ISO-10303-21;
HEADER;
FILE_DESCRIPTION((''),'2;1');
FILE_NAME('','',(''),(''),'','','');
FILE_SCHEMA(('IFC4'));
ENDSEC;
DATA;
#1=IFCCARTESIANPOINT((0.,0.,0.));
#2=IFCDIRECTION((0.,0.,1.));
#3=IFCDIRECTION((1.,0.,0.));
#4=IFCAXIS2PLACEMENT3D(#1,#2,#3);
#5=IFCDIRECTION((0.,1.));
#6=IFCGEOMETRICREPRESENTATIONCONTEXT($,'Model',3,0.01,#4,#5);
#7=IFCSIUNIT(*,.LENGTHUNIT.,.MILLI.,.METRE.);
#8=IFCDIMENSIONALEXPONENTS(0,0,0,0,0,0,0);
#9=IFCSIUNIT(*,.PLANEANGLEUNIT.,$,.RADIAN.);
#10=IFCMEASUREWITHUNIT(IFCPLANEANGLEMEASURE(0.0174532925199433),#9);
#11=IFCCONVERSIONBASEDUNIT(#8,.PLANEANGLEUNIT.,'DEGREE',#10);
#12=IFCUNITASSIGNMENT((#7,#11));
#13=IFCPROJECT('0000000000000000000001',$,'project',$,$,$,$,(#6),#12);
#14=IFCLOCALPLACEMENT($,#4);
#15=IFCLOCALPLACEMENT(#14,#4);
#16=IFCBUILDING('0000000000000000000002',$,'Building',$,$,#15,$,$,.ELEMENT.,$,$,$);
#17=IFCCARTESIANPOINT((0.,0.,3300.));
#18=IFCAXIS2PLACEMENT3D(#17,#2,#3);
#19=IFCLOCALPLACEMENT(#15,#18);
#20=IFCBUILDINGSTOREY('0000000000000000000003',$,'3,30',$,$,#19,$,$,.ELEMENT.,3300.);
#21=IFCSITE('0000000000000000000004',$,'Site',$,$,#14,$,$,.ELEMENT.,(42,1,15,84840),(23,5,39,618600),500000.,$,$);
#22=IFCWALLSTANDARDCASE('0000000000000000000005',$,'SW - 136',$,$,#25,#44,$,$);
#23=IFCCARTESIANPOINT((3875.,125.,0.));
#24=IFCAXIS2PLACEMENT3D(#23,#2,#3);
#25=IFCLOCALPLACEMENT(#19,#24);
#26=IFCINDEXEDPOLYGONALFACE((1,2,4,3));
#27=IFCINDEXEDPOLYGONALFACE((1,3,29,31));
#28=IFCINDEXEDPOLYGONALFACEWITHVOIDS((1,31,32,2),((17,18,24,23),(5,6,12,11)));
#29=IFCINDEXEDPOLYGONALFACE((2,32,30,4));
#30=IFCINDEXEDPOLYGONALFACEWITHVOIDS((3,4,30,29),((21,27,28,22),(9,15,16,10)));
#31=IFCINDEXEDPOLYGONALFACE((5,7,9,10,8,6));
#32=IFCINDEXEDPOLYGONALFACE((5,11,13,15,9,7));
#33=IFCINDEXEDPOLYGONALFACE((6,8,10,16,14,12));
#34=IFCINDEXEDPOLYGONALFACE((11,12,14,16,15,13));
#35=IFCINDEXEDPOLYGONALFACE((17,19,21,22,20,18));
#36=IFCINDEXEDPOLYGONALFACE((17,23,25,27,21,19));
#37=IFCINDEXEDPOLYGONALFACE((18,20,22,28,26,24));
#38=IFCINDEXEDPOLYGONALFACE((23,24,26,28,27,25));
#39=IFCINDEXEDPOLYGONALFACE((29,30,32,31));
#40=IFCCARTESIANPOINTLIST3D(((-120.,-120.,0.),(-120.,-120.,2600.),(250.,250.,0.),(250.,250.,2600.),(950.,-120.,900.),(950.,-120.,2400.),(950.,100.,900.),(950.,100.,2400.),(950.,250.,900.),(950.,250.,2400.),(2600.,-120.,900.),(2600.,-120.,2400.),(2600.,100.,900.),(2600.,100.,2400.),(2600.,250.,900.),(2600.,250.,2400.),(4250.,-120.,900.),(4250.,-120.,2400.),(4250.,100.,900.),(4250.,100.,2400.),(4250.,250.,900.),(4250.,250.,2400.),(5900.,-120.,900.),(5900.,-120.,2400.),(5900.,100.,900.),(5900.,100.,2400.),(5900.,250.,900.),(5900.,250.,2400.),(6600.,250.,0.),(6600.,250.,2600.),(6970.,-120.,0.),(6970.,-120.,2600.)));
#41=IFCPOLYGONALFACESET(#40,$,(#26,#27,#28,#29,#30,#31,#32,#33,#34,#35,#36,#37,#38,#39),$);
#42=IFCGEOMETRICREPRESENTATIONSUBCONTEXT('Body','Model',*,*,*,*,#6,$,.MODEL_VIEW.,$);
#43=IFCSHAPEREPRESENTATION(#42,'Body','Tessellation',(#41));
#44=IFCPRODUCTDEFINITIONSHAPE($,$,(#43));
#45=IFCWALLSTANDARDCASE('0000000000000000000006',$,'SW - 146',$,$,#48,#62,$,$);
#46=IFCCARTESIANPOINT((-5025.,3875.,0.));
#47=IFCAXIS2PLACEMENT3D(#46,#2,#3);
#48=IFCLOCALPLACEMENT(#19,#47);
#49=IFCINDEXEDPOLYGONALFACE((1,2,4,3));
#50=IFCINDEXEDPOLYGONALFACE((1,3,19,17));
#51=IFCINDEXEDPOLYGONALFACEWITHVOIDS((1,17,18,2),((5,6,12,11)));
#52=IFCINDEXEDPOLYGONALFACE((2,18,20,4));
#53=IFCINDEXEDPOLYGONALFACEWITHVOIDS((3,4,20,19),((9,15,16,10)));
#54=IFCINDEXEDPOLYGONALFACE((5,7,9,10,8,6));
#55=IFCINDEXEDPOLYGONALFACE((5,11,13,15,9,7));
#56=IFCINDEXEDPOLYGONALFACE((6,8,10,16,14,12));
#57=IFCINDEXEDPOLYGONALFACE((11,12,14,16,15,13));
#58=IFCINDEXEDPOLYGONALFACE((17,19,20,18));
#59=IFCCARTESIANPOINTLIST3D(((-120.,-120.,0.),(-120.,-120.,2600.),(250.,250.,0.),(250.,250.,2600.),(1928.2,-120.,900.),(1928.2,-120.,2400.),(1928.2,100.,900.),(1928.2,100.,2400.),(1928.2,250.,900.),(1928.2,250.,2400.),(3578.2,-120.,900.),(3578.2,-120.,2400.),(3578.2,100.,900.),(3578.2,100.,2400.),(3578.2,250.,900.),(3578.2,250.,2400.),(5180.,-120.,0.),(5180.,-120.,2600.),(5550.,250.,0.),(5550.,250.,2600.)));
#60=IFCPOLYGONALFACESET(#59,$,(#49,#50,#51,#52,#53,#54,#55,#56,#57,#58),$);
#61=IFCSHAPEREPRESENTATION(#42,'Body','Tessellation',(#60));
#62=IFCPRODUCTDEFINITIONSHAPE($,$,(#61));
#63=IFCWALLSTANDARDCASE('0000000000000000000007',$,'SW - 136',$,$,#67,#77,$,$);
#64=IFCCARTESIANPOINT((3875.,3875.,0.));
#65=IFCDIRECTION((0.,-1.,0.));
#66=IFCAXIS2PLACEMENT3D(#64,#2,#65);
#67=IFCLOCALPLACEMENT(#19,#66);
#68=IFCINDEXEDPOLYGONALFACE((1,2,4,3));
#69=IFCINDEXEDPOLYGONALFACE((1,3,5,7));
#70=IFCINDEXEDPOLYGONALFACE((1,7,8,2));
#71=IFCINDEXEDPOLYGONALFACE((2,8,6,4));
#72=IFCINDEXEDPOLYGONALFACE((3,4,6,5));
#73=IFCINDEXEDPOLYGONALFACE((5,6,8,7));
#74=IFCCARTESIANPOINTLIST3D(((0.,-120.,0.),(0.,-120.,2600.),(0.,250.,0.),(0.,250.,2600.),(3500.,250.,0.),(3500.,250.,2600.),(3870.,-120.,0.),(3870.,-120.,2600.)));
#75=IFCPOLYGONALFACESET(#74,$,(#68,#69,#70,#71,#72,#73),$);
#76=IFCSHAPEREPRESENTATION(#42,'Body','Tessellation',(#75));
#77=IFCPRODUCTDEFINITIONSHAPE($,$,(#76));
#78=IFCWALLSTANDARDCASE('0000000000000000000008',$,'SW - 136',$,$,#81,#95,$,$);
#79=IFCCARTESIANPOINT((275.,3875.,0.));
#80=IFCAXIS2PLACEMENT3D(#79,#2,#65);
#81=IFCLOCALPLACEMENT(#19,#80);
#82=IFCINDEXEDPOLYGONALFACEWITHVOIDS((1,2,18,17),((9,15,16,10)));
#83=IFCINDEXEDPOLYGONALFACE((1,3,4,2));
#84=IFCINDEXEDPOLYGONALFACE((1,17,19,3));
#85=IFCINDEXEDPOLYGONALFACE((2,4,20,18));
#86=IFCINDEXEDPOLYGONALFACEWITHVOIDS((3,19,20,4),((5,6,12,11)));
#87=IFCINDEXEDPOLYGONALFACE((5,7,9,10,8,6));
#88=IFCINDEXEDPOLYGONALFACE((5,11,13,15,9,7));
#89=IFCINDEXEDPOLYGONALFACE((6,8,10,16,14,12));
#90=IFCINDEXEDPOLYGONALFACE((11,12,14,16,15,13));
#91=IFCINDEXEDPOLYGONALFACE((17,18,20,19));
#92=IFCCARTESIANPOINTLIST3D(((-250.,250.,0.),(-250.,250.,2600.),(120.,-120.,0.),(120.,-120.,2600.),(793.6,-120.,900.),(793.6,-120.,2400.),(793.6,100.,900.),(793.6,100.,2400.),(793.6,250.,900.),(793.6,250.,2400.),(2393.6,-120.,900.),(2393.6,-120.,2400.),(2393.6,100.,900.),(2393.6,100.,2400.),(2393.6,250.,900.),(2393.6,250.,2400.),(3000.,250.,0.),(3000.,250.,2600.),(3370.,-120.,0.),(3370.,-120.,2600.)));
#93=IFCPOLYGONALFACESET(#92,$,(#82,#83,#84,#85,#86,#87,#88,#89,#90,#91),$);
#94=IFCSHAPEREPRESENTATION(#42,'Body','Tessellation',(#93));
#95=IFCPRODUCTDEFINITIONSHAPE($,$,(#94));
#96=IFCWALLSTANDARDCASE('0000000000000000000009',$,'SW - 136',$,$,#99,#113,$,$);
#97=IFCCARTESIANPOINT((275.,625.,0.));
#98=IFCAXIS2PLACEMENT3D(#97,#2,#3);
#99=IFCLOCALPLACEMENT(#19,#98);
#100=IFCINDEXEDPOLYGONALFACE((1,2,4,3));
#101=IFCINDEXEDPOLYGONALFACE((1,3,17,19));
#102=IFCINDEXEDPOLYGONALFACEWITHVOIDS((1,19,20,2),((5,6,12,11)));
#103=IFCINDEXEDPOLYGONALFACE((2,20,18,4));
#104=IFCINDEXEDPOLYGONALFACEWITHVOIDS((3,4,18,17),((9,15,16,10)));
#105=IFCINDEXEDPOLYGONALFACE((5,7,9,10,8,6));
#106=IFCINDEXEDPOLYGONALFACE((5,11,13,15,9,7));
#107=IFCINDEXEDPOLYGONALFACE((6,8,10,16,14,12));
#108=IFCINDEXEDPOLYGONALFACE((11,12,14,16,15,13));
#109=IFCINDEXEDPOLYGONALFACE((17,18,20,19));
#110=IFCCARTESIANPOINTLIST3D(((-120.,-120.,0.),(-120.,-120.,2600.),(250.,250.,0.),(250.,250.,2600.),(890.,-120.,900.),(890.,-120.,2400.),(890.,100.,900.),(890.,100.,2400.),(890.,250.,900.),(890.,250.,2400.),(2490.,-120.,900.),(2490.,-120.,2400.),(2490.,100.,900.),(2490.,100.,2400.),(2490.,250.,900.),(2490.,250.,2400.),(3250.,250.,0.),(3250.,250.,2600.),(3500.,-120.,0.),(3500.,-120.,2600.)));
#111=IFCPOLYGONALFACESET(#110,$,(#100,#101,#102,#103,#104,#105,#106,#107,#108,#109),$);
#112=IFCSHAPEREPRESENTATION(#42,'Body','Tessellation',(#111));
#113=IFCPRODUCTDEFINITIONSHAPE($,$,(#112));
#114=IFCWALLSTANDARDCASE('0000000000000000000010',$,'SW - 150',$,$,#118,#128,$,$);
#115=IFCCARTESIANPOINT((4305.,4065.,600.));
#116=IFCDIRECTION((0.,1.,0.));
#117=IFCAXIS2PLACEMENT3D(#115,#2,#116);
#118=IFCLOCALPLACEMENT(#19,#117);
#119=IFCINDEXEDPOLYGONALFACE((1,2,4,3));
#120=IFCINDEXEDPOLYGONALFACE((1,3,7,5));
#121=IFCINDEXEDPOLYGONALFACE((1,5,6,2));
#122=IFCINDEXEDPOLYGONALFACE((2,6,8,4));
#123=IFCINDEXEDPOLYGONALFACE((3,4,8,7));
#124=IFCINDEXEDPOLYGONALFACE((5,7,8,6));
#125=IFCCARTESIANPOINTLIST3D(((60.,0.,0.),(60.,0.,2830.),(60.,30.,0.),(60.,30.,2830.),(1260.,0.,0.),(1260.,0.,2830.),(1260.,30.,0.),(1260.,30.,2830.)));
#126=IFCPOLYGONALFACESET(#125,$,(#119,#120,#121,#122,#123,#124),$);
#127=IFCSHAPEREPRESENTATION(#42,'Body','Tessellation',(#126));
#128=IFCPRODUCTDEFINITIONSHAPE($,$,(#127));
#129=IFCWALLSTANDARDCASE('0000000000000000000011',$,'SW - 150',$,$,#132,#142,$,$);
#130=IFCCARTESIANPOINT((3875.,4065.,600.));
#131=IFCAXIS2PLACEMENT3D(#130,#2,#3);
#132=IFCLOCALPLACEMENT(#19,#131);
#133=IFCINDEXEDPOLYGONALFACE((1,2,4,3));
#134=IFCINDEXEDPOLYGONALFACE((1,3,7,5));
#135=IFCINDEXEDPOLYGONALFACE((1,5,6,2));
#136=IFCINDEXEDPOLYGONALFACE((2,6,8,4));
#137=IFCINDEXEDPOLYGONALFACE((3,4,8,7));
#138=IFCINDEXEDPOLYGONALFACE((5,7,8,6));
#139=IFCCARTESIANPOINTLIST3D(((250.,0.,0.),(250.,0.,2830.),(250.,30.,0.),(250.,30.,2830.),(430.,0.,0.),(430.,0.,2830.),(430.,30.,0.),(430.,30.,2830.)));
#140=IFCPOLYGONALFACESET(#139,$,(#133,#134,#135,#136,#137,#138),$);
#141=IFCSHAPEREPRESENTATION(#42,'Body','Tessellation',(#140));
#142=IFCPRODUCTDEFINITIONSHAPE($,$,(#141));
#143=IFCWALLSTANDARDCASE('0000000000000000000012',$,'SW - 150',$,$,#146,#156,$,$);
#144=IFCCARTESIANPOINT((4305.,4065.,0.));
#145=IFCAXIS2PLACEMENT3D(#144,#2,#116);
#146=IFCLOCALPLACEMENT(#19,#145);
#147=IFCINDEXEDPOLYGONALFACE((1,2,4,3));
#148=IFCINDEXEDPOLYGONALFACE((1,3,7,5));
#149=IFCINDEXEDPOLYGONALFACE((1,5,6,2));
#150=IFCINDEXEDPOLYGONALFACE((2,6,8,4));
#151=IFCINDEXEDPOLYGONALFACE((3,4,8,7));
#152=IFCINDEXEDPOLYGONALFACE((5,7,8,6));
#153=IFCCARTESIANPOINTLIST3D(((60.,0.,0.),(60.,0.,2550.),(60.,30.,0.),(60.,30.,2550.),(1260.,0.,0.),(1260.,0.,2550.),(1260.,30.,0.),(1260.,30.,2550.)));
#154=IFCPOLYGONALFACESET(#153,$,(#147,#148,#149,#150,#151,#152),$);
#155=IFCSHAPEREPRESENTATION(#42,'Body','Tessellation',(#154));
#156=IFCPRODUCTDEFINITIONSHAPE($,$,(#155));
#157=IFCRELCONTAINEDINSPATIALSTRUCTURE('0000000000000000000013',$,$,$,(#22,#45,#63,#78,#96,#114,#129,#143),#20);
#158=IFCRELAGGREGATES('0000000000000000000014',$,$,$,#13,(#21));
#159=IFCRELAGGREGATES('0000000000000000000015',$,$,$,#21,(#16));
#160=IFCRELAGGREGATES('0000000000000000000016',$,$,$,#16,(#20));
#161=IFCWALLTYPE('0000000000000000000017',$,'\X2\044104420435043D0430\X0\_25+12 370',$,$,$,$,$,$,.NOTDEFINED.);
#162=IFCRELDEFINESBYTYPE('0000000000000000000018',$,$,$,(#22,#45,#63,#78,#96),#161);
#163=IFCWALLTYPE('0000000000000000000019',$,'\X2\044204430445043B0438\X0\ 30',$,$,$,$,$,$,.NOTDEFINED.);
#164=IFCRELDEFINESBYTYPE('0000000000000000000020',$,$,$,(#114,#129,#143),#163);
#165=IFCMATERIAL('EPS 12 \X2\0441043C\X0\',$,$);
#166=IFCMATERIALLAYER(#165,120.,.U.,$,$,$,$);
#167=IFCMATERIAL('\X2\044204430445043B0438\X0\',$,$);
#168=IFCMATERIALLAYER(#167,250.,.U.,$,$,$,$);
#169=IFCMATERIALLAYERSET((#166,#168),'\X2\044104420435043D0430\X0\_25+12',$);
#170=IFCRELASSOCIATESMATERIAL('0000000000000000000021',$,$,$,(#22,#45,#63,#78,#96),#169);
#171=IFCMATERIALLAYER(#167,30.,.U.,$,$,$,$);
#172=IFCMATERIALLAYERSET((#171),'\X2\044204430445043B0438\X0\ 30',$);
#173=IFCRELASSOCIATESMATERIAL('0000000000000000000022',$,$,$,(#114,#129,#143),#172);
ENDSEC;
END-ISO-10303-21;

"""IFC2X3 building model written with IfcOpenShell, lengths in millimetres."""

from ifc_helpers import new_model, entity, si_unit, converted_unit, direction, frame, origin_with_axes, origin_2d_with_axis, place, context, subcontext, project, spatial, polyline, rectangle, outline, extrude, material, layer, layer_set, layer_usage, type_object, element, save


model = new_model("IFC2X3")

# Units and contexts
model_context = context("Model", 3, precision=0.01, world=origin_with_axes(), true_north=direction((0.0, 1.0)))
body_context = subcontext(model_context, "Body", "Model", "MODEL_VIEW")
ifc_project = project(units=[si_unit("LENGTHUNIT", "METRE", prefix="MILLI"), converted_unit("PLANEANGLEUNIT", "DEGREE", entity("IfcPlaneAngleMeasure", 0.0174532925199433), si_unit("PLANEANGLEUNIT", "RADIAN"), dimensions=[0, 0, 0, 0, 0, 0, 0])], contexts=[model_context])

# Site, building, storey
site_placement = place(None, origin_with_axes())
site = spatial("IfcSite", under=ifc_project, at=site_placement, Name="Site", CompositionType="ELEMENT", RefLatitude=(42, 1, 15, 84840), RefLongitude=(23, 5, 39, 618600), RefElevation=500000.0)
building_placement = place(site_placement, origin_with_axes())
building = spatial("IfcBuilding", under=site, at=building_placement, Name="Building", CompositionType="ELEMENT")
storey_placement = place(building_placement, frame((0.0, 0.0, 3300.0), z_axis=(0.0, 0.0, 1.0), x_axis=(1.0, 0.0, 0.0)))
storey = spatial("IfcBuildingStorey", under=building, at=storey_placement, Name="3,30", CompositionType="ELEMENT", Elevation=3300.0)

# Wall, openings
ifc_material_1 = material(Name="EPS 12 см")
ifc_layer_1 = layer(ifc_material_1, 120.0, ventilated="UNKNOWN")
ifc_material_2 = material(Name="тухли")
ifc_layer_2 = layer(ifc_material_2, 250.0, ventilated="UNKNOWN")
ifc_layer_set_1 = layer_set([ifc_layer_1, ifc_layer_2], Name="стена_25+12")
ifc_layer_usage_1 = layer_usage(ifc_layer_set_1, "AXIS2", "POSITIVE", -120.0)
wall_type_1 = type_object("IfcWallType", Name="стена_25+12 370", PredefinedType="NOTDEFINED")
wall_1_placement = place(storey_placement, frame((3875.0, 125.0, 0.0), z_axis=(0.0, 0.0, 1.0), x_axis=(1.0, 0.0, 0.0)))
wall_1 = element("IfcWallStandardCase", 1, at=wall_1_placement, inside=storey, type_object=wall_type_1, material=ifc_layer_usage_1, Name="SW - 136", context=body_context, shape_type="SweptSolid", body=[
    extrude(outline(polyline([(-120.0, -120.0), (6970.0, -120.0), (6600.0, 250.0), (250.0, 250.0), (-120.0, -120.0)])), origin_with_axes(), (0.0, 0.0, 1.0), 2600.0),
])
opening_1_placement = place(wall_1_placement, frame((5075.0, 0.0, 900.0), z_axis=(0.0, 0.0, 1.0), x_axis=(1.0, 0.0, 0.0)))
element("IfcOpeningElement", 2, at=opening_1_placement, cuts=wall_1, context=body_context, shape_type="SweptSolid", body=[
    extrude(rectangle(XDim=1650.0, YDim=1500.0, at=origin_2d_with_axis()), frame((0.0, 100.0, 750.0), z_axis=(0.0, -1.0, 0.0), x_axis=(-1.0, 0.0, 0.0)), (0.0, 0.0, 1.0), 590.0),
    extrude(rectangle(XDim=1650.0, YDim=1500.0, at=origin_2d_with_axis()), frame((0.0, 100.0, 750.0), z_axis=(0.0, 1.0, 0.0), x_axis=(-1.0, 0.0, 0.0)), (0.0, 0.0, 1.0), 520.0),
])
opening_2_placement = place(wall_1_placement, frame((1775.0, 0.0, 900.0), z_axis=(0.0, 0.0, 1.0), x_axis=(1.0, 0.0, 0.0)))
element("IfcOpeningElement", 3, at=opening_2_placement, cuts=wall_1, context=body_context, shape_type="SweptSolid", body=[
    extrude(rectangle(XDim=1650.0, YDim=1500.0, at=origin_2d_with_axis()), frame((0.0, 100.0, 750.0), z_axis=(0.0, -1.0, 0.0), x_axis=(-1.0, 0.0, 0.0)), (0.0, 0.0, 1.0), 590.0),
    extrude(rectangle(XDim=1650.0, YDim=1500.0, at=origin_2d_with_axis()), frame((0.0, 100.0, 750.0), z_axis=(0.0, 1.0, 0.0), x_axis=(-1.0, 0.0, 0.0)), (0.0, 0.0, 1.0), 520.0),
])

# Wall, opening
ifc_layer_usage_2 = layer_usage(ifc_layer_set_1, "AXIS2", "POSITIVE", -120.0)
wall_2_placement = place(storey_placement, frame((-5025.0, 3875.0, 0.0), z_axis=(0.0, 0.0, 1.0), x_axis=(1.0, 0.0, 0.0)))
wall_2 = element("IfcWallStandardCase", 4, at=wall_2_placement, inside=storey, type_object=wall_type_1, material=ifc_layer_usage_2, Name="SW - 146", context=body_context, shape_type="SweptSolid", body=[
    extrude(outline(polyline([(-120.0, -120.0), (5180.0, -120.0), (5550.0, 250.0), (250.0, 250.0), (-120.0, -120.0)])), origin_with_axes(), (0.0, 0.0, 1.0), 2600.0),
])
opening_3_placement = place(wall_2_placement, frame((2753.2, 0.0, 900.0), z_axis=(0.0, 0.0, 1.0), x_axis=(1.0, 0.0, 0.0)))
element("IfcOpeningElement", 5, at=opening_3_placement, cuts=wall_2, context=body_context, shape_type="SweptSolid", body=[
    extrude(rectangle(XDim=1650.0, YDim=1500.0, at=origin_2d_with_axis()), frame((0.0, 100.0, 750.0), z_axis=(0.0, -1.0, 0.0), x_axis=(-1.0, 0.0, 0.0)), (0.0, 0.0, 1.0), 590.0),
    extrude(rectangle(XDim=1650.0, YDim=1500.0, at=origin_2d_with_axis()), frame((0.0, 100.0, 750.0), z_axis=(0.0, 1.0, 0.0), x_axis=(-1.0, 0.0, 0.0)), (0.0, 0.0, 1.0), 520.0),
])

# Wall
ifc_layer_usage_3 = layer_usage(ifc_layer_set_1, "AXIS2", "POSITIVE", -120.0)
wall_3_placement = place(storey_placement, frame((3875.0, 3875.0, 0.0), z_axis=(0.0, 0.0, 1.0), x_axis=(0.0, -1.0, 0.0)))
element("IfcWallStandardCase", 6, at=wall_3_placement, inside=storey, type_object=wall_type_1, material=ifc_layer_usage_3, Name="SW - 136", context=body_context, shape_type="SweptSolid", body=[
    extrude(outline(polyline([(0.0, -120.0), (3870.0, -120.0), (3500.0, 250.0), (0.0, 250.0), (0.0, -120.0)])), origin_with_axes(), (0.0, 0.0, 1.0), 2600.0),
])

# Walls, openings
ifc_layer_usage_4 = layer_usage(ifc_layer_set_1, "AXIS2", "POSITIVE", -120.0)
wall_4_placement = place(storey_placement, frame((275.0, 3875.0, 0.0), z_axis=(0.0, 0.0, 1.0), x_axis=(0.0, -1.0, 0.0)))
wall_4 = element("IfcWallStandardCase", 7, at=wall_4_placement, inside=storey, type_object=wall_type_1, material=ifc_layer_usage_4, Name="SW - 136", context=body_context, shape_type="SweptSolid", body=[
    extrude(outline(polyline([(120.0, -120.0), (3370.0, -120.0), (3000.0, 250.0), (-250.0, 250.0), (120.0, -120.0)])), origin_with_axes(), (0.0, 0.0, 1.0), 2600.0),
])
opening_4_placement = place(wall_4_placement, frame((1593.6, 0.0, 900.0), z_axis=(0.0, 0.0, 1.0), x_axis=(1.0, 0.0, 0.0)))
element("IfcOpeningElement", 8, at=opening_4_placement, cuts=wall_4, context=body_context, shape_type="SweptSolid", body=[
    extrude(rectangle(XDim=1600.0, YDim=1500.0, at=origin_2d_with_axis()), frame((0.0, 100.0, 750.0), z_axis=(0.0, -1.0, 0.0), x_axis=(-1.0, 0.0, 0.0)), (0.0, 0.0, 1.0), 590.0),
    extrude(rectangle(XDim=1600.0, YDim=1500.0, at=origin_2d_with_axis()), frame((0.0, 100.0, 750.0), z_axis=(0.0, 1.0, 0.0), x_axis=(-1.0, 0.0, 0.0)), (0.0, 0.0, 1.0), 520.0),
])
ifc_layer_usage_5 = layer_usage(ifc_layer_set_1, "AXIS2", "POSITIVE", -120.0)
wall_5_placement = place(storey_placement, frame((275.0, 625.0, 0.0), z_axis=(0.0, 0.0, 1.0), x_axis=(1.0, 0.0, 0.0)))
wall_5 = element("IfcWallStandardCase", 9, at=wall_5_placement, inside=storey, type_object=wall_type_1, material=ifc_layer_usage_5, Name="SW - 136", context=body_context, shape_type="SweptSolid", body=[
    extrude(outline(polyline([(-120.0, -120.0), (3500.0, -120.0), (3250.0, 250.0), (250.0, 250.0), (-120.0, -120.0)])), origin_with_axes(), (0.0, 0.0, 1.0), 2600.0),
])
opening_5_placement = place(wall_5_placement, frame((1690.0, 0.0, 900.0), z_axis=(0.0, 0.0, 1.0), x_axis=(1.0, 0.0, 0.0)))
element("IfcOpeningElement", 10, at=opening_5_placement, cuts=wall_5, context=body_context, shape_type="SweptSolid", body=[
    extrude(rectangle(XDim=1600.0, YDim=1500.0, at=origin_2d_with_axis()), frame((0.0, 100.0, 750.0), z_axis=(0.0, -1.0, 0.0), x_axis=(-1.0, 0.0, 0.0)), (0.0, 0.0, 1.0), 590.0),
    extrude(rectangle(XDim=1600.0, YDim=1500.0, at=origin_2d_with_axis()), frame((0.0, 100.0, 750.0), z_axis=(0.0, 1.0, 0.0), x_axis=(-1.0, 0.0, 0.0)), (0.0, 0.0, 1.0), 520.0),
])

# Walls
ifc_layer_3 = layer(ifc_material_2, 30.0, ventilated="UNKNOWN")
ifc_layer_set_2 = layer_set([ifc_layer_3], Name="тухли 30")
ifc_layer_usage_6 = layer_usage(ifc_layer_set_2, "AXIS2", "POSITIVE", 0.0)
wall_type_2 = type_object("IfcWallType", Name="тухли 30", PredefinedType="NOTDEFINED")
wall_6_placement = place(storey_placement, frame((4305.0, 4065.0, 600.0), z_axis=(0.0, 0.0, 1.0), x_axis=(0.0, 1.0, 0.0)))
element("IfcWallStandardCase", 11, at=wall_6_placement, inside=storey, type_object=wall_type_2, material=ifc_layer_usage_6, Name="SW - 150", context=body_context, shape_type="SweptSolid", body=[
    extrude(outline(polyline([(60.0, 0.0), (1260.0, 0.0), (1260.0, 30.0), (60.0, 30.0), (60.0, 0.0)])), origin_with_axes(), (0.0, 0.0, 1.0), 2830.0),
])
ifc_layer_usage_7 = layer_usage(ifc_layer_set_2, "AXIS2", "POSITIVE", 0.0)
wall_7_placement = place(storey_placement, frame((3875.0, 4065.0, 600.0), z_axis=(0.0, 0.0, 1.0), x_axis=(1.0, 0.0, 0.0)))
element("IfcWallStandardCase", 12, at=wall_7_placement, inside=storey, type_object=wall_type_2, material=ifc_layer_usage_7, Name="SW - 150", context=body_context, shape_type="SweptSolid", body=[
    extrude(outline(polyline([(250.0, 0.0), (430.0, 0.0), (430.0, 30.0), (250.0, 30.0), (250.0, 0.0)])), origin_with_axes(), (0.0, 0.0, 1.0), 2830.0),
])
ifc_layer_usage_8 = layer_usage(ifc_layer_set_2, "AXIS2", "POSITIVE", 0.0)
wall_8_placement = place(storey_placement, frame((4305.0, 4065.0, 0.0), z_axis=(0.0, 0.0, 1.0), x_axis=(0.0, 1.0, 0.0)))
element("IfcWallStandardCase", 13, at=wall_8_placement, inside=storey, type_object=wall_type_2, material=ifc_layer_usage_8, Name="SW - 150", context=body_context, shape_type="SweptSolid", body=[
    extrude(outline(polyline([(60.0, 0.0), (1260.0, 0.0), (1260.0, 30.0), (60.0, 30.0), (60.0, 0.0)])), origin_with_axes(), (0.0, 0.0, 1.0), 2550.0),
])

save(model, "model.ifc")
